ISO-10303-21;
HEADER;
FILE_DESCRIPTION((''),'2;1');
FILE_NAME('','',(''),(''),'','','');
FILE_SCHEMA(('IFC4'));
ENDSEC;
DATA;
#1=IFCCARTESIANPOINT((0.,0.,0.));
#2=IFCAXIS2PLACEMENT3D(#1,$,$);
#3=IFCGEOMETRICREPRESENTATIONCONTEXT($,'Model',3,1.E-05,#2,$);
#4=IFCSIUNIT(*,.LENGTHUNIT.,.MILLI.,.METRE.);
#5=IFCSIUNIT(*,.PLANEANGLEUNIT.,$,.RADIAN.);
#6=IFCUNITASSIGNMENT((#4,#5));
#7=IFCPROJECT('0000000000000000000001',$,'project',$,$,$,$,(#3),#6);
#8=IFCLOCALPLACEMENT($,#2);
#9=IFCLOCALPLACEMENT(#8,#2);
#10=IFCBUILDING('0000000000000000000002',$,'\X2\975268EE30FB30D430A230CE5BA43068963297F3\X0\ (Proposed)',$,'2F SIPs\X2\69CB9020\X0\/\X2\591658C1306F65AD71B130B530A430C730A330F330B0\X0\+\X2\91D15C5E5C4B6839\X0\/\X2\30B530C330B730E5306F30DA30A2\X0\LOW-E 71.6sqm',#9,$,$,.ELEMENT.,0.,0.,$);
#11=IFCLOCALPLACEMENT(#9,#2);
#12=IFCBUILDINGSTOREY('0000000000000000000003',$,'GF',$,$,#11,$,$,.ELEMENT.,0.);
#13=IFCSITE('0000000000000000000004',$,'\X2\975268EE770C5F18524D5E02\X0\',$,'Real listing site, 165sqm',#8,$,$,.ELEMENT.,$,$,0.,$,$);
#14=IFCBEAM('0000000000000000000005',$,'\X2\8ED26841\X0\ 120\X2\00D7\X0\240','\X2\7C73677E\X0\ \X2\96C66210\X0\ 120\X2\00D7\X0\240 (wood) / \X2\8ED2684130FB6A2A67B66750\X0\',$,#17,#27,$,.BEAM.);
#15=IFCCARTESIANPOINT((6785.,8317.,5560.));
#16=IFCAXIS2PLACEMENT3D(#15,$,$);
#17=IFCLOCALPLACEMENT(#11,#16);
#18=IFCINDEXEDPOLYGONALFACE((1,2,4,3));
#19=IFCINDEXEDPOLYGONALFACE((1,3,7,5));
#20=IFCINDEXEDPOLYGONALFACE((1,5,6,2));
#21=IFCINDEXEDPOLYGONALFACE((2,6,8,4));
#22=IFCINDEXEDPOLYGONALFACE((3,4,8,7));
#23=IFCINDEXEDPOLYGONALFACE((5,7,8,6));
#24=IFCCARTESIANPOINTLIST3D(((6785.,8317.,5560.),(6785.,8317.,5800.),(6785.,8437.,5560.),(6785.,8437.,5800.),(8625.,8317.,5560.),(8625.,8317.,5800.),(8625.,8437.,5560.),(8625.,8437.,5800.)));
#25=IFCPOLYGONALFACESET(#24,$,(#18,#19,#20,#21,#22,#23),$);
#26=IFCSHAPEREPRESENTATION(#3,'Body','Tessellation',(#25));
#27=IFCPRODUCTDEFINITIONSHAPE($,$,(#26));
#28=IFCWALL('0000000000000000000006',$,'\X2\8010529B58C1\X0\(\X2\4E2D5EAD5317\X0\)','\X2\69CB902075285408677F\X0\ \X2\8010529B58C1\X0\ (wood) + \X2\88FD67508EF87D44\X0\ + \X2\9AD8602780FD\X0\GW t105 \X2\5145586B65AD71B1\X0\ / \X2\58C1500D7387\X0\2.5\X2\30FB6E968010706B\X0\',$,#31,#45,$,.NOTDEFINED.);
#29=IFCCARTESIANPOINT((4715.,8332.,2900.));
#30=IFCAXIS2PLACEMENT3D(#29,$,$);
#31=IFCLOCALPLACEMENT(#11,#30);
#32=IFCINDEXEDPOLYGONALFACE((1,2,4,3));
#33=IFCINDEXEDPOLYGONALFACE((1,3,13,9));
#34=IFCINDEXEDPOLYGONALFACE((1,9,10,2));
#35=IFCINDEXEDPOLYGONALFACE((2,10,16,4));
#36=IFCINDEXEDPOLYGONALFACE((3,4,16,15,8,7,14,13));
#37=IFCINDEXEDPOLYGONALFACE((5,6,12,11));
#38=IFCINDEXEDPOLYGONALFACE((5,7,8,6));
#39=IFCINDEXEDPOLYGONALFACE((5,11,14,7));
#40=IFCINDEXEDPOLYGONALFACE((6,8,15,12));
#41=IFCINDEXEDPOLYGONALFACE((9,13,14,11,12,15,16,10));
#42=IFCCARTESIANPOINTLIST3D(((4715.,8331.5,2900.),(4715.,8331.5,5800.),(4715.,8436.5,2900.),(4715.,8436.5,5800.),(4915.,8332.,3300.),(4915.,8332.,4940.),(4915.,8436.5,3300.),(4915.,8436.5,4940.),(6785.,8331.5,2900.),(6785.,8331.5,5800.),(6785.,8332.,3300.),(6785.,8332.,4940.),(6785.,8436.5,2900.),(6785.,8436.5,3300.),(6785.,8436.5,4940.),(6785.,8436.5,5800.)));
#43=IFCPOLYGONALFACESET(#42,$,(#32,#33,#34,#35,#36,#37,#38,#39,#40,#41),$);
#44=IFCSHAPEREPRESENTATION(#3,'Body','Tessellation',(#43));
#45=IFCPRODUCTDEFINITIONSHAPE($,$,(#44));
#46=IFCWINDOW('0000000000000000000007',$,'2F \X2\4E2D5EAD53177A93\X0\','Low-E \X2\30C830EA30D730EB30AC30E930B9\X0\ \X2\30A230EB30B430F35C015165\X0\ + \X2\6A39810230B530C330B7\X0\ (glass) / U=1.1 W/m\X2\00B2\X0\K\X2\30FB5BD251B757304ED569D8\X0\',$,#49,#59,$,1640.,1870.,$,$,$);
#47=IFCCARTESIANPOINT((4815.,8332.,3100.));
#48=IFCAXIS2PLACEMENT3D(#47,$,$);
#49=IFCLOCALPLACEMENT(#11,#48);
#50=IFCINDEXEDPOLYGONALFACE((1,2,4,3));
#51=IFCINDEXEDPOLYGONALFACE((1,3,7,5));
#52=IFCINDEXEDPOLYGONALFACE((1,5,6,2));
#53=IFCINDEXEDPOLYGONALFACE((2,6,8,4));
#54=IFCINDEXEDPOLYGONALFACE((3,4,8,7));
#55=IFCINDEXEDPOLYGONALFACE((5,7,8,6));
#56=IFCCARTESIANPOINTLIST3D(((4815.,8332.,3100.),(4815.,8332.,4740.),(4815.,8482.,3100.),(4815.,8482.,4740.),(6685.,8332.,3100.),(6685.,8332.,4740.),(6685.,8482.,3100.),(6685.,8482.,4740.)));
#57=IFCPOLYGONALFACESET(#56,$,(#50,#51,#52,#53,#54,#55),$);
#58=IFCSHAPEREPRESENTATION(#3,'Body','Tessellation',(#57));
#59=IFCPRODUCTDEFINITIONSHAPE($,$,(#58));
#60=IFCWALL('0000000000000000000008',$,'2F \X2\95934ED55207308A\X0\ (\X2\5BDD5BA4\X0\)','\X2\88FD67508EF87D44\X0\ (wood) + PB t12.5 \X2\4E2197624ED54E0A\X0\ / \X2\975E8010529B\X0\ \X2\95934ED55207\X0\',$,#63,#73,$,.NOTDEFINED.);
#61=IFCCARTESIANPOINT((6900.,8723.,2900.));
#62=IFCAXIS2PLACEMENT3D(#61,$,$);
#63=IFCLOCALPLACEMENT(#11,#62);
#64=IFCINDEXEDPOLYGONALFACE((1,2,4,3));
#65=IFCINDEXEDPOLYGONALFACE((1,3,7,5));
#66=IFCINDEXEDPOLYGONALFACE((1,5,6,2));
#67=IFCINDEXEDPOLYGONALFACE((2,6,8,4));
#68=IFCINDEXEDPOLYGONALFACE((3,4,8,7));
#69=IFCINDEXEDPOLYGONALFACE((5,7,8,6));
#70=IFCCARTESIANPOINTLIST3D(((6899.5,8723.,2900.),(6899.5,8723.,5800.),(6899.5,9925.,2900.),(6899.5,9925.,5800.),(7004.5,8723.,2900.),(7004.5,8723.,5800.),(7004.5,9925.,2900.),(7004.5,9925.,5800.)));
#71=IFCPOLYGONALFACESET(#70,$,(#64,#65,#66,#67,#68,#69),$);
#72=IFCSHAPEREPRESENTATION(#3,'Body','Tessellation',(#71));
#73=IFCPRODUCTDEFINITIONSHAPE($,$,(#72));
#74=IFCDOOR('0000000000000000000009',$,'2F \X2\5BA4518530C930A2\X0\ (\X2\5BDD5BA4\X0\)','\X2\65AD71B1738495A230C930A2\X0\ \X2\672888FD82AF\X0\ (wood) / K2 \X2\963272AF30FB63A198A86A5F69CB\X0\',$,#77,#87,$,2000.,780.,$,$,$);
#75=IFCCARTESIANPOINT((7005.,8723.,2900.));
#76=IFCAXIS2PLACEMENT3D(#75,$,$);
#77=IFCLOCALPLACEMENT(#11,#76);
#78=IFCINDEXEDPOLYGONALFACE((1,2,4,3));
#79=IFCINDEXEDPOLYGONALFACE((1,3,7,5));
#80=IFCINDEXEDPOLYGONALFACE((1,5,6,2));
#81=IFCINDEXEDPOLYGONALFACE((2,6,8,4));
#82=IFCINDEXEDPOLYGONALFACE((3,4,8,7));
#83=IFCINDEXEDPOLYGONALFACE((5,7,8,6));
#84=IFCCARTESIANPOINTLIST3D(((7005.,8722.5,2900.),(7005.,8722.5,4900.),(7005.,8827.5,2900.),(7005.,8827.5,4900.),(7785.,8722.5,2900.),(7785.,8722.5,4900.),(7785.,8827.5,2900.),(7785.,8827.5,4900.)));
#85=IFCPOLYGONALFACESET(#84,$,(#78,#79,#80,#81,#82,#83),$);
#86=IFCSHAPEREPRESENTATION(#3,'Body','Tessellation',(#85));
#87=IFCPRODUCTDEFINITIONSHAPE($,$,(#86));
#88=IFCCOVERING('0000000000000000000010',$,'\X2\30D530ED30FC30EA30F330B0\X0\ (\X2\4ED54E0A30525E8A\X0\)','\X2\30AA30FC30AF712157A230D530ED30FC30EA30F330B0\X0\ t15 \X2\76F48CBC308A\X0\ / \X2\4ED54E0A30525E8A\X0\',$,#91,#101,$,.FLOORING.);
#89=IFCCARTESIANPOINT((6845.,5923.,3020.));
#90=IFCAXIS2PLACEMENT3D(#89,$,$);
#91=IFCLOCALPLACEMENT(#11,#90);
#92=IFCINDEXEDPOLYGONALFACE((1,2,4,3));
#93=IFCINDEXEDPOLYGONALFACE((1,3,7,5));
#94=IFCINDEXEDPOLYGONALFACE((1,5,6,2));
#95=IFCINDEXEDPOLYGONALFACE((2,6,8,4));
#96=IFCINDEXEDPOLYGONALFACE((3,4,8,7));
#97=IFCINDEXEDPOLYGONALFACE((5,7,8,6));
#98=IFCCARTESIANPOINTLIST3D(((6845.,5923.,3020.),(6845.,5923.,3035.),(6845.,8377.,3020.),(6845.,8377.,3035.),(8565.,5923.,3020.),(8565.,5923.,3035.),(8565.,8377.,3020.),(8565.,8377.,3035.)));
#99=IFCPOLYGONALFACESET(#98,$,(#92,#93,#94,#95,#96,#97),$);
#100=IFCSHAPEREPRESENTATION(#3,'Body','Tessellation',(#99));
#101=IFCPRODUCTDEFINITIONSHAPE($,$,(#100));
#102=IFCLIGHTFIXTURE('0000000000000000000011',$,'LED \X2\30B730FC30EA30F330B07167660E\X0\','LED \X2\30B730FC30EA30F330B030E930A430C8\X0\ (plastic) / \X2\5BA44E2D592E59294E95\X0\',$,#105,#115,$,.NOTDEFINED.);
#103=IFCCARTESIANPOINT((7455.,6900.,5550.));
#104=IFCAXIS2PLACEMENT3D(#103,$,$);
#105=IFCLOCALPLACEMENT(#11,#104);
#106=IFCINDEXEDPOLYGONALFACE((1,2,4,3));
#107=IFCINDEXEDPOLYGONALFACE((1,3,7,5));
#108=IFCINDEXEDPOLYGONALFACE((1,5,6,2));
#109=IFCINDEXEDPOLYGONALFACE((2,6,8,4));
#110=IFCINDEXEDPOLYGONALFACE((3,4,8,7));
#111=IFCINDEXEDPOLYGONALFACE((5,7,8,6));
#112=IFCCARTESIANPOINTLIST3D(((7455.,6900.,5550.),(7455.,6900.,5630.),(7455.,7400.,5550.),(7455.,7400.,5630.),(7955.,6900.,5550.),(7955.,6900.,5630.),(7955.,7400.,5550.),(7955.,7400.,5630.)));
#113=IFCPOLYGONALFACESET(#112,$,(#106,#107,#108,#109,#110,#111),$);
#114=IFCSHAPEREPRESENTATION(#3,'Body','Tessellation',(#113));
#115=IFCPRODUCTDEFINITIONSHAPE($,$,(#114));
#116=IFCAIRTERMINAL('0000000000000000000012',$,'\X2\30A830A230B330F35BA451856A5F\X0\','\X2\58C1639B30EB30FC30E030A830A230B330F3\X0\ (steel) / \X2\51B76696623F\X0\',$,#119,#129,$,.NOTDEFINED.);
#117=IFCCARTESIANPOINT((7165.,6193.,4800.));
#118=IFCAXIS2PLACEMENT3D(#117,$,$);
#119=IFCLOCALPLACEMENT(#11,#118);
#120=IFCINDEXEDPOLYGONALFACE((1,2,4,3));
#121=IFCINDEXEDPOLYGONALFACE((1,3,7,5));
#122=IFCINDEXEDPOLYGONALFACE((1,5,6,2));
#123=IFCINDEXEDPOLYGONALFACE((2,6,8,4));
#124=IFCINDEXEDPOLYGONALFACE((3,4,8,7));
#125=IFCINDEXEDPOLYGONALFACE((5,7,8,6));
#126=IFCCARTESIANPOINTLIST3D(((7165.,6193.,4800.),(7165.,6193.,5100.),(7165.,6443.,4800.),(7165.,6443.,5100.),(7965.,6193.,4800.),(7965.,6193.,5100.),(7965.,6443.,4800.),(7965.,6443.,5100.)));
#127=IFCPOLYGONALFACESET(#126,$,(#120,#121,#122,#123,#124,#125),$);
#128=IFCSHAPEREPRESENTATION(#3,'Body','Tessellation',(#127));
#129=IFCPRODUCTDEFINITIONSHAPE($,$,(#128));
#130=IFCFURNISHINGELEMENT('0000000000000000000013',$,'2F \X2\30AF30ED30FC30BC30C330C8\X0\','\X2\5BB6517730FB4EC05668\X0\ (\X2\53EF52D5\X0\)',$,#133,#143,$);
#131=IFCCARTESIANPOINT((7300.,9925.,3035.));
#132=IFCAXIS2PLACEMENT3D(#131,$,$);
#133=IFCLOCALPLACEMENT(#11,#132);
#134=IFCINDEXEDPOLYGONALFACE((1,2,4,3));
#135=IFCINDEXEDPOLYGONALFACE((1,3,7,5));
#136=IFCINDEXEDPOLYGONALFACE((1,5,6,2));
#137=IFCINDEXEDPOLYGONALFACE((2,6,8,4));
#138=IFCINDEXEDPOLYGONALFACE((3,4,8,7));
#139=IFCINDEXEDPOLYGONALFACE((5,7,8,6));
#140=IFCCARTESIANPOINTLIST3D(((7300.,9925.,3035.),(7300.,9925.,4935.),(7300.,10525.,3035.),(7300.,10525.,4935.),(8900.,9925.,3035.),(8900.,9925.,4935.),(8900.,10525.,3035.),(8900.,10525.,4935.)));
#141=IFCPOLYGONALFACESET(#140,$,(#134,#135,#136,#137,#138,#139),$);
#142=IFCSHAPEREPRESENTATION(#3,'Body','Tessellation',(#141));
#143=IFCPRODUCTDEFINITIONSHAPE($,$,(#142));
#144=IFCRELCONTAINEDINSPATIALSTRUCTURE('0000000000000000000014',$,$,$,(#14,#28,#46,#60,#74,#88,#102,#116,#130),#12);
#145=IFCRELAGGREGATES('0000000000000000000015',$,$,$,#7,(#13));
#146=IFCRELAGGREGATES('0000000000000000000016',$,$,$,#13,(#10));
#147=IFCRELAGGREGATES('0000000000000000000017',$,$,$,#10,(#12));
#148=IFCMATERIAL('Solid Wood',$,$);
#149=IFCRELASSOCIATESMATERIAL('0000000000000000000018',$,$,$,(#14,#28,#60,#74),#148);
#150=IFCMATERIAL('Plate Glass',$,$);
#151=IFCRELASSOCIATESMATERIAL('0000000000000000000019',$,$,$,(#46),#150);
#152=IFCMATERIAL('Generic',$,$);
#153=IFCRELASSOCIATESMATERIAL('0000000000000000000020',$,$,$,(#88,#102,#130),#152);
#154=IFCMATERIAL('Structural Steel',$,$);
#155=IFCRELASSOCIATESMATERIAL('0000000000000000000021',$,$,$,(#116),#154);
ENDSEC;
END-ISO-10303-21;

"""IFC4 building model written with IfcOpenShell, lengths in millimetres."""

from ifc_helpers import new_model, si_unit, frame, frame_2d, origin, place, context, project, spatial, rectangle, extrude, material, element, fill, save


model = new_model("IFC4")

# Units and contexts
model_context = context("Model", 3, precision=1e-05, world=origin())
ifc_project = project(units=[si_unit("LENGTHUNIT", "METRE", prefix="MILLI"), si_unit("PLANEANGLEUNIT", "RADIAN")], contexts=[model_context])

# Site, building, storey
site_placement = place(None, origin())
site = spatial("IfcSite", under=ifc_project, at=site_placement, Name="青森県弘前市", ObjectType="Real listing site, 165sqm", CompositionType="ELEMENT", RefElevation=0.0)
building_placement = place(site_placement, origin())
building = spatial("IfcBuilding", under=site, at=building_placement, Name="青森・ピアノ室と防音 (Proposed)", ObjectType="2F SIPs構造/外壁は断熱サイディング+金属屋根/サッシュはペアLOW-E 71.6sqm", CompositionType="ELEMENT", ElevationOfRefHeight=0.0, ElevationOfTerrain=0.0)
storey_placement = place(building_placement, origin())
storey = spatial("IfcBuildingStorey", under=building, at=storey_placement, Name="GF", CompositionType="ELEMENT", Elevation=0.0)

# Shared definitions
ifc_material_1 = material(Name="Solid Wood")

# Beam
beam_1_placement = place(storey_placement, frame((6785.0, 8317.0, 5560.0)))
element("IfcBeam", 1, at=beam_1_placement, inside=storey, material=ifc_material_1, Name="軒桁 120×240", Description="米松 集成 120×240 (wood) / 軒桁・横架材", PredefinedType="BEAM", context=model_context, shape_type="SweptSolid", body=[
    extrude(rectangle(XDim=1840.0, YDim=120.0, at=frame_2d((920.0, 60.0))), frame((6785.0, 8317.0, 5560.0)), (0.0, 0.0, 1.0), 240.0),
])

# Wall, opening, window
wall_1_placement = place(storey_placement, frame((4715.0, 8332.0, 2900.0)))
wall_1 = element("IfcWall", 2, at=wall_1_placement, inside=storey, material=ifc_material_1, Name="耐力壁(中庭北)", Description="構造用合板 耐力壁 (wood) + 製材軸組 + 高性能GW t105 充填断熱 / 壁倍率2.5・準耐火", PredefinedType="NOTDEFINED", context=model_context, shape_type="SweptSolid", body=[
    extrude(rectangle(XDim=2070.0, YDim=105.0, at=frame_2d((1035.0, 52.0))), frame((4715.0, 8332.0, 2900.0)), (0.0, 0.0, 1.0), 2900.0),
])
opening_placement = place(storey_placement, frame((4815.0, 8332.0, 3100.0)))
opening = element("IfcOpeningElement", 3, at=opening_placement, cuts=wall_1, PredefinedType="NOTDEFINED", context=model_context, shape_type="SweptSolid", body=[
    extrude(rectangle(XDim=1870.0, YDim=150.0, at=frame_2d((935.0, 75.0))), frame((4815.0, 8332.0, 3100.0)), (0.0, 0.0, 1.0), 1640.0),
])
ifc_material_2 = material(Name="Plate Glass")
window_placement = place(storey_placement, frame((4815.0, 8332.0, 3100.0)))
window = element("IfcWindow", 4, at=window_placement, inside=storey, material=ifc_material_2, Name="2F 中庭北窓", Description="Low-E トリプルガラス アルゴン封入 + 樹脂サッシ (glass) / U=1.1 W/m²K・寒冷地仕様", OverallHeight=1640.0, OverallWidth=1870.0, context=model_context, shape_type="SweptSolid", body=[
    extrude(rectangle(XDim=1870.0, YDim=150.0, at=frame_2d((935.0, 75.0))), frame((4815.0, 8332.0, 3100.0)), (0.0, 0.0, 1.0), 1640.0),
])
fill(opening, window)

# Wall
wall_2_placement = place(storey_placement, frame((6900.0, 8723.0, 2900.0)))
element("IfcWall", 5, at=wall_2_placement, inside=storey, material=ifc_material_1, Name="2F 間仕切り (寝室)", Description="製材軸組 (wood) + PB t12.5 両面仕上 / 非耐力 間仕切", PredefinedType="NOTDEFINED", context=model_context, shape_type="SweptSolid", body=[
    extrude(rectangle(XDim=105.0, YDim=1202.0, at=frame_2d((52.0, 601.0))), frame((6900.0, 8723.0, 2900.0)), (0.0, 0.0, 1.0), 2900.0),
])

# Door
door_placement = place(storey_placement, frame((7005.0, 8723.0, 2900.0)))
element("IfcDoor", 6, at=door_placement, inside=storey, material=ifc_material_1, Name="2F 室内ドア (寝室)", Description="断熱玄関ドア 木製芯 (wood) / K2 防犯・採風機構", OverallHeight=2000.0, OverallWidth=780.0, context=model_context, shape_type="SweptSolid", body=[
    extrude(rectangle(XDim=780.0, YDim=105.0, at=frame_2d((390.0, 52.0))), frame((7005.0, 8723.0, 2900.0)), (0.0, 0.0, 1.0), 2000.0),
])

# Covering
ifc_material_3 = material(Name="Generic")
covering_placement = place(storey_placement, frame((6845.0, 5923.0, 3020.0)))
element("IfcCovering", 7, at=covering_placement, inside=storey, material=ifc_material_3, Name="フローリング (仕上げ床)", Description="オーク無垢フローリング t15 直貼り / 仕上げ床", PredefinedType="FLOORING", context=model_context, shape_type="SweptSolid", body=[
    extrude(rectangle(XDim=1720.0, YDim=2454.0, at=frame_2d((860.0, 1227.0))), frame((6845.0, 5923.0, 3020.0)), (0.0, 0.0, 1.0), 15.0),
])

# Light fixture
light_fixture_placement = place(storey_placement, frame((7455.0, 6900.0, 5550.0)))
element("IfcLightFixture", 8, at=light_fixture_placement, inside=storey, material=ifc_material_3, Name="LED シーリング照明", Description="LED シーリングライト (plastic) / 室中央天井", PredefinedType="NOTDEFINED", context=model_context, shape_type="SweptSolid", body=[
    extrude(rectangle(XDim=500.0, YDim=500.0, at=frame_2d((250.0, 250.0))), frame((7455.0, 6900.0, 5550.0)), (0.0, 0.0, 1.0), 80.0),
])

# Air terminal
ifc_material_4 = material(Name="Structural Steel")
air_terminal_placement = place(storey_placement, frame((7165.0, 6193.0, 4800.0)))
element("IfcAirTerminal", 9, at=air_terminal_placement, inside=storey, material=ifc_material_4, Name="エアコン室内機", Description="壁掛ルームエアコン (steel) / 冷暖房", PredefinedType="NOTDEFINED", context=model_context, shape_type="SweptSolid", body=[
    extrude(rectangle(XDim=800.0, YDim=250.0, at=frame_2d((400.0, 125.0))), frame((7165.0, 6193.0, 4800.0)), (0.0, 0.0, 1.0), 300.0),
])

# Furnishing element
furnishing_placement = place(storey_placement, frame((7300.0, 9925.0, 3035.0)))
element("IfcFurnishingElement", 10, at=furnishing_placement, inside=storey, material=ifc_material_3, Name="2F クローゼット", Description="家具・什器 (可動)", context=model_context, shape_type="SweptSolid", body=[
    extrude(rectangle(XDim=1600.0, YDim=600.0, at=frame_2d((800.0, 300.0))), frame((7300.0, 9925.0, 3035.0)), (0.0, 0.0, 1.0), 1900.0),
])

save(model, "model.ifc")
